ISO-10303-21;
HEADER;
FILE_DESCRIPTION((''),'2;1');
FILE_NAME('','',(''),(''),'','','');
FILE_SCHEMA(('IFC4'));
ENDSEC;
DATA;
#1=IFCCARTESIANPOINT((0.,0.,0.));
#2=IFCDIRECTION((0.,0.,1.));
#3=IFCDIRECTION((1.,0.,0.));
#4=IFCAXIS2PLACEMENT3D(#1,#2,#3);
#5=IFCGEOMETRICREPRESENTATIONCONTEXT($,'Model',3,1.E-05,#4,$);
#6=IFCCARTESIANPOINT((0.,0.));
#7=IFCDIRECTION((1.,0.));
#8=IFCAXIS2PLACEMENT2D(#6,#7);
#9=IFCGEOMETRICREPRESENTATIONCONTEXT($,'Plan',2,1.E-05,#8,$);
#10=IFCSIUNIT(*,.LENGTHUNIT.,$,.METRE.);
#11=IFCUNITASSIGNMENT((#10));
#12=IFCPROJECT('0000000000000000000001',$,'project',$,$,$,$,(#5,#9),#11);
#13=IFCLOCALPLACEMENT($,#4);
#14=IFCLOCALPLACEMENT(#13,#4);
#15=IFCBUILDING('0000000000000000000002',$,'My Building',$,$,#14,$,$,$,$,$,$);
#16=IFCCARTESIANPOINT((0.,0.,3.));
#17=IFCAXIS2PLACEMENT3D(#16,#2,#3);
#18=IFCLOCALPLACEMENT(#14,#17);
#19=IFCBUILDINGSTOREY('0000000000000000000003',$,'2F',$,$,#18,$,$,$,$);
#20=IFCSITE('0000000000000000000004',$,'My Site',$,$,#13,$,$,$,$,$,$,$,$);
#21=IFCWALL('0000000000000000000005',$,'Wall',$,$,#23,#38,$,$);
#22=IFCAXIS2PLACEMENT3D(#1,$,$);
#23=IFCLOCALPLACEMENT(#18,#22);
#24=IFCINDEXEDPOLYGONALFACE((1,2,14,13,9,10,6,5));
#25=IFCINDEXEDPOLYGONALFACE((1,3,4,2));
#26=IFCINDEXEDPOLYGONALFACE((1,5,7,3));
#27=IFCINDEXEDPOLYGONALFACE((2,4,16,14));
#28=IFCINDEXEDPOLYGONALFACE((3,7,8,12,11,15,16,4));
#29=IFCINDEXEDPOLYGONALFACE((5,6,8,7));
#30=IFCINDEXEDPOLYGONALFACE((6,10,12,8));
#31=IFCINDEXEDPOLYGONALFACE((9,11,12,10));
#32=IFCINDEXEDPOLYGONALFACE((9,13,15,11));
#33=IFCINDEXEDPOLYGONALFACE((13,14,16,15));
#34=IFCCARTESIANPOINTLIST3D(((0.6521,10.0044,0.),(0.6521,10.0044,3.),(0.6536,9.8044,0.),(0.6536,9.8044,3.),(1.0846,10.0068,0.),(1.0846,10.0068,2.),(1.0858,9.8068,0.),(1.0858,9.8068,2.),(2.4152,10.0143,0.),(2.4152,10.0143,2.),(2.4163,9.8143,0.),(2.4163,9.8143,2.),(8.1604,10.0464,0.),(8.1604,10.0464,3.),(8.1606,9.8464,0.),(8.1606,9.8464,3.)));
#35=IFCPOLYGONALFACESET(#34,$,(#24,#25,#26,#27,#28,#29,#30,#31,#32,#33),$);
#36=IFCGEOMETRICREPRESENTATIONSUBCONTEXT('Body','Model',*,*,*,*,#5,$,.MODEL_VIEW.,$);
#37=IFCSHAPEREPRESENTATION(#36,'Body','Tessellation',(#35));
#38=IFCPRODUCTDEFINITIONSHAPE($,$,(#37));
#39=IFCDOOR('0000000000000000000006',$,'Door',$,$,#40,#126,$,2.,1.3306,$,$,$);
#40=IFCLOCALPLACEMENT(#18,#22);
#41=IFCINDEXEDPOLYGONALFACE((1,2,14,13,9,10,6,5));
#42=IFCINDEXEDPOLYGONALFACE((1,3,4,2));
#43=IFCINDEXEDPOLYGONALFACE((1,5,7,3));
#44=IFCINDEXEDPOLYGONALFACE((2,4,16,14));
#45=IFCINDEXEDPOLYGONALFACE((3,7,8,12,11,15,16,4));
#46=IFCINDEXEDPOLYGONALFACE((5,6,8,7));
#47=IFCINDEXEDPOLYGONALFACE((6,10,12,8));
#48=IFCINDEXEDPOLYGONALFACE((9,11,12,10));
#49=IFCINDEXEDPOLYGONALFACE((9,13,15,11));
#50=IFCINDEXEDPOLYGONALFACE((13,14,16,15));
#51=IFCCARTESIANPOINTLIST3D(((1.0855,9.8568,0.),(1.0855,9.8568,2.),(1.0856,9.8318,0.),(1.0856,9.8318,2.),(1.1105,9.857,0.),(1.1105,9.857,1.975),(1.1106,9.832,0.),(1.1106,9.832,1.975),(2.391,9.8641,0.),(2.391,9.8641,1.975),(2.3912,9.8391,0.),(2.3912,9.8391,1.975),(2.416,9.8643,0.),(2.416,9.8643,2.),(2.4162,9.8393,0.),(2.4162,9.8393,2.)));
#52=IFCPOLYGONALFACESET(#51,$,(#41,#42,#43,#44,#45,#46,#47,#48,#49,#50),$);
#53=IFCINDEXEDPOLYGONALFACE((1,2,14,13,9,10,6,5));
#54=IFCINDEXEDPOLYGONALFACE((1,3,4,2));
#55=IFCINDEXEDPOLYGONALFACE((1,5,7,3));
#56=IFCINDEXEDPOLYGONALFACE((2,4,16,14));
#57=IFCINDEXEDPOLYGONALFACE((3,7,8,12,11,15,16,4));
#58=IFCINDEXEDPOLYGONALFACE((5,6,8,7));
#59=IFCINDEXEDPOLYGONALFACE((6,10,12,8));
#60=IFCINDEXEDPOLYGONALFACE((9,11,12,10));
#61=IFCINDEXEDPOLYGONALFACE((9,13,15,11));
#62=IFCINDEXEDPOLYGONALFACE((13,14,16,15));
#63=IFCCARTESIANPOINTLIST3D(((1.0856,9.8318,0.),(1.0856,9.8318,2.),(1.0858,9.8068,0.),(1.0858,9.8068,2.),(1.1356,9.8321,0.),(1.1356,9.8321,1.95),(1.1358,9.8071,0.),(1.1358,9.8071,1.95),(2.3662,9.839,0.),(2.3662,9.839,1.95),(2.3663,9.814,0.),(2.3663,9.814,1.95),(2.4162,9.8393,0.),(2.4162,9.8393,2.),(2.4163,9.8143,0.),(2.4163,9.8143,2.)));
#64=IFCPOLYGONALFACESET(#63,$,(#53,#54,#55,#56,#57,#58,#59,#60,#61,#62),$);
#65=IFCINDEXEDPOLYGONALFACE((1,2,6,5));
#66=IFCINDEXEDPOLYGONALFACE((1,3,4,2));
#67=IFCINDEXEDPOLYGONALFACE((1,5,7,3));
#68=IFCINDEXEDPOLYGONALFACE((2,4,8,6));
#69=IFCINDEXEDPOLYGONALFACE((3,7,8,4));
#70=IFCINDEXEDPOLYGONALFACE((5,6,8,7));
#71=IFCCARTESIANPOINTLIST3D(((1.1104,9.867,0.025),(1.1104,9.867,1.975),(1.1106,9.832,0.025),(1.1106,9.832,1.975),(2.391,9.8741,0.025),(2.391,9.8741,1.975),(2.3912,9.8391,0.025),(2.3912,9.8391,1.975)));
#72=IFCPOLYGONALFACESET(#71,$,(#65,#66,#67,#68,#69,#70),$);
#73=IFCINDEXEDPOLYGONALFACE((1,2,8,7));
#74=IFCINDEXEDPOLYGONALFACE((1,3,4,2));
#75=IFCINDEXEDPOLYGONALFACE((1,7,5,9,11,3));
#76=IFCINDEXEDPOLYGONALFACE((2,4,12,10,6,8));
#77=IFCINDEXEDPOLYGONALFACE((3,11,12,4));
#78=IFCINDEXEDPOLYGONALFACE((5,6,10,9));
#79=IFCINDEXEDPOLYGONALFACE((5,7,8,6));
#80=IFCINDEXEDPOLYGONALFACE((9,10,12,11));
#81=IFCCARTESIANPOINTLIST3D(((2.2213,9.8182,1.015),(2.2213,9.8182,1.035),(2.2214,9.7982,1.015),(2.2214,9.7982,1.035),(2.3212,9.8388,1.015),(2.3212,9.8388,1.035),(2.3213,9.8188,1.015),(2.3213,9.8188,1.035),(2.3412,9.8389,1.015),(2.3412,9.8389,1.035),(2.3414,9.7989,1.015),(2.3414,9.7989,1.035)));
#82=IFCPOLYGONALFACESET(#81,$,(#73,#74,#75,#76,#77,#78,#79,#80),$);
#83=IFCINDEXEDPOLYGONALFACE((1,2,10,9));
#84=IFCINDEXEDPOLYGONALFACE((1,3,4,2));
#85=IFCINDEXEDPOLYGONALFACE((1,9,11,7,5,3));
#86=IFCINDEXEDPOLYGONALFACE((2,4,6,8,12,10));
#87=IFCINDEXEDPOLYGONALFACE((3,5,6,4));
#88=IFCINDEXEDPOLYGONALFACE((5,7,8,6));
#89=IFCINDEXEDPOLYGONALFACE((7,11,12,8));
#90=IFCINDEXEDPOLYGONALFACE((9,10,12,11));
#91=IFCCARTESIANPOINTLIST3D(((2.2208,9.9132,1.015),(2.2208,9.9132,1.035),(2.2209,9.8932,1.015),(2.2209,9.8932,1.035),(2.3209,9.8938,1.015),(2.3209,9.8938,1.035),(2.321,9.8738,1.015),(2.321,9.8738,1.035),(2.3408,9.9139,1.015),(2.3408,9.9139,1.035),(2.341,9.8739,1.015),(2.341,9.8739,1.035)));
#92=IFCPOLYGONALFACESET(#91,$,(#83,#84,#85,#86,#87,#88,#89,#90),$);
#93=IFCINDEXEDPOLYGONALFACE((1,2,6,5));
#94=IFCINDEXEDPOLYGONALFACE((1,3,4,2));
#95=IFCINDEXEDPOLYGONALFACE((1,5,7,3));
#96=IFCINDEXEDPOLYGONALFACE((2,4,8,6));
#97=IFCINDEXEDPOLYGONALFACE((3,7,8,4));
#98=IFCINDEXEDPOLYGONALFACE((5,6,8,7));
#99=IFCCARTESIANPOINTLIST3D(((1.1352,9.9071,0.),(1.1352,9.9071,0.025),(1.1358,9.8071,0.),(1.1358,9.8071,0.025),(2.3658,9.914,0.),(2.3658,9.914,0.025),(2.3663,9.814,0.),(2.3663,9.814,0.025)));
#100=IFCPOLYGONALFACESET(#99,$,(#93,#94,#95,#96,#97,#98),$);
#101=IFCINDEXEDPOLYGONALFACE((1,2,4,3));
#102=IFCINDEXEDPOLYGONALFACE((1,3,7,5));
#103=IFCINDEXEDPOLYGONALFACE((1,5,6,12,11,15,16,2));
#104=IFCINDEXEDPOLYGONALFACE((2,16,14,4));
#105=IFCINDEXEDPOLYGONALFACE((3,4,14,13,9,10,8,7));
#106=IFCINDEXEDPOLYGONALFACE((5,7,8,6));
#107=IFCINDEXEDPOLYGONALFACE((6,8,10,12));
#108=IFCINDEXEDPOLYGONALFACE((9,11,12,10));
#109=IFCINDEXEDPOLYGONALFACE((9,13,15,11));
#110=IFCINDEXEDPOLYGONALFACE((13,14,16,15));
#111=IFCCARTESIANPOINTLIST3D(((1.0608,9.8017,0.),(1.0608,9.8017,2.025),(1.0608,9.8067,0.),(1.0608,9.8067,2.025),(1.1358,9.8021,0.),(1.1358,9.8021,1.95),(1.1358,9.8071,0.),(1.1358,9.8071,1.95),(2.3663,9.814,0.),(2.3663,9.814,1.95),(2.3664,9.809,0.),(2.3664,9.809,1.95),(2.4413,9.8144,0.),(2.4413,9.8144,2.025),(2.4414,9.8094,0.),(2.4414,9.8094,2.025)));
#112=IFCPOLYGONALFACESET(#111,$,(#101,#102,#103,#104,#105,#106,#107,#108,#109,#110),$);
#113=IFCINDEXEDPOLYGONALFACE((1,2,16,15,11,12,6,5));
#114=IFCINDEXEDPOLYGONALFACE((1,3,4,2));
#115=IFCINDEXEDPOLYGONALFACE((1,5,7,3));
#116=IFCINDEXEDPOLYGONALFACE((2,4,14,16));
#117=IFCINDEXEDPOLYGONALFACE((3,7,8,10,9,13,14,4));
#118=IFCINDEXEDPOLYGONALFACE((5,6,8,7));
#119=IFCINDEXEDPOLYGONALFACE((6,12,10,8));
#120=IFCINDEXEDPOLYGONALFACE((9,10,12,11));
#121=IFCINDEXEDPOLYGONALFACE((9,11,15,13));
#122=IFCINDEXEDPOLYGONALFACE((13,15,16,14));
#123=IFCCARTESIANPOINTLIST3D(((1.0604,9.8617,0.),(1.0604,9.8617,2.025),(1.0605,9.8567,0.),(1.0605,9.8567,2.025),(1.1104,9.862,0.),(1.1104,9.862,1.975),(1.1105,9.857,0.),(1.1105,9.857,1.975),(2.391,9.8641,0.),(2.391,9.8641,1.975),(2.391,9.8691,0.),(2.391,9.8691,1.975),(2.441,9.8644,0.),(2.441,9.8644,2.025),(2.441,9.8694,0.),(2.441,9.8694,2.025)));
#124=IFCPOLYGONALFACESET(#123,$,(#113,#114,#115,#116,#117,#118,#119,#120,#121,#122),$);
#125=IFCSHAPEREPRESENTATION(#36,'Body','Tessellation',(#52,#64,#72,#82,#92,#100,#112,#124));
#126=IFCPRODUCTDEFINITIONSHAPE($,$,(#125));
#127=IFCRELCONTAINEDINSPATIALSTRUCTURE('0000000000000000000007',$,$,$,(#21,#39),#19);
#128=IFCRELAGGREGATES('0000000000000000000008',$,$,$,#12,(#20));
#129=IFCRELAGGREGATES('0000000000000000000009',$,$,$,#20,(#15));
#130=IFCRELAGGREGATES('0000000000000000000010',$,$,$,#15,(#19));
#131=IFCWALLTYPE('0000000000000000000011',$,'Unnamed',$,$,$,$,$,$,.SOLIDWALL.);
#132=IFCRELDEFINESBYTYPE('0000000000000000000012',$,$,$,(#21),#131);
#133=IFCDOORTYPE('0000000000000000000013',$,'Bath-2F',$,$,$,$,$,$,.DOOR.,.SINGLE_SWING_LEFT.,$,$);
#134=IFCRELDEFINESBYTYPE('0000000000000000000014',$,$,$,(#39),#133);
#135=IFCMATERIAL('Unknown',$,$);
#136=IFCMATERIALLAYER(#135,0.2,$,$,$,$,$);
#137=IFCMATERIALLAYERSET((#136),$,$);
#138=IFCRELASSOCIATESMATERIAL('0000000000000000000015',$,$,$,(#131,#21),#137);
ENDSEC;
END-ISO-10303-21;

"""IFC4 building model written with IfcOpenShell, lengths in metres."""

from ifc_helpers import new_model, entity, si_unit, frame, origin_with_axes, origin_2d_with_axis, place, context, subcontext, project, spatial, line, indexed_curve, outline, extrude, shape, source, transform, mapped, material, layer, layer_set, layer_usage, type_object, type_shapes, element, fill, save


model = new_model("IFC4")

# Units and contexts
model_context = context("Model", 3, precision=1e-05, world=origin_with_axes())
plan_context = context("Plan", 2, precision=1e-05, world=origin_2d_with_axis())
body_context_1 = subcontext(model_context, "Body", "Model", "MODEL_VIEW")
body_context_2 = subcontext(plan_context, "Body", "Plan", "PLAN_VIEW")
ifc_project = project(units=[si_unit("LENGTHUNIT", "METRE")], contexts=[model_context, plan_context])

# Site, building, storey
site_placement = place(None, origin_with_axes())
site = spatial("IfcSite", under=ifc_project, at=site_placement, Name="My Site")
building_placement = place(site_placement, origin_with_axes())
building = spatial("IfcBuilding", under=site, at=building_placement, Name="My Building")
storey_placement = place(building_placement, frame((0.0, 0.0, 3.0), z_axis=(0.0, 0.0, 1.0), x_axis=(1.0, 0.0, 0.0)))
storey = spatial("IfcBuildingStorey", under=building, at=storey_placement, Name="2F")

# Shared definitions
ifc_material = material(Name="Unknown")

# Shared definitions
ifc_layer_1 = layer(ifc_material, 0.2)
ifc_layer_set_1 = layer_set([ifc_layer_1])
wall_type = type_object("IfcWallType", Name="Unnamed", PredefinedType="SOLIDWALL", material=ifc_layer_set_1)

# Wall, opening, door
ifc_layer_usage_1 = layer_usage(ifc_layer_set_1, "AXIS2", "POSITIVE", 0.0)
wall_1_placement = place(storey_placement, frame((0.4536, 9.8033, 0.0), z_axis=(0.0, 0.0, 1.0), x_axis=(0.999984, 0.00559, 0.0)))
wall_1 = element("IfcWall", 1, at=wall_1_placement, inside=storey, type_object=wall_type, material=ifc_layer_usage_1, Name="Wall", context=body_context_1, shape_type="SweptSolid", body=[
    extrude(outline(indexed_curve([(0.2, 0.0), (0.1997, 0.2), (7.708, 0.2), (7.7071, 0.0)], segments=[line(1, 2, 3, 4, 1)])), origin_with_axes(), (0.0, 0.0, 1.0), 3.0),
])
shared_shape_1 = source(origin_with_axes(), body_context_1, "Body", "SweptSolid", [
    extrude(outline(indexed_curve([(0.0, 0.0), (1.3306, 0.0), (1.3306, 2.0), (0.0, 2.0)], segments=[line(1, 2, 3, 4, 1)])), frame((0.0, -0.6, 0.0), z_axis=(0.0, -1.0, 0.0), x_axis=(1.0, 0.0, 0.0)), (0.0, 0.0, -1.0), 1.2),
])
opening_1_placement = place(wall_1_placement, frame((0.6322, 0.0, 0.0), z_axis=(0.0, 0.0, 1.0), x_axis=(1.0, 0.0, 0.0)))
opening_1 = element("IfcOpeningElement", 2, at=opening_1_placement, cuts=wall_1, PredefinedType="OPENING", context=body_context_1, shape_type="MappedRepresentation", body=[
    mapped(shared_shape_1, transform((0.0, 0.0, 0.0), x_axis=(1.0, 0.0, 0.0), y_axis=(0.0, 1.0, 0.0), z_axis=(0.0, 0.0, 1.0), scale=1.0)),
])
door_type_1 = type_object("IfcDoorType", Name="Bath-2F", OperationType="SINGLE_SWING_LEFT", PredefinedType="DOOR")
shared_shape_2 = source(origin_with_axes(), body_context_1, "Body", "SweptSolid", [
    extrude(outline(indexed_curve([(0.0, 0.0), (0.0, 2.0), (1.3306, 2.0), (1.3306, 0.0), (1.3056, 0.0), (1.3056, 1.975), (0.025, 1.975), (0.025, 0.0)], segments=[line(1, 2, 3, 4, 5, 6, 7, 8, 1)])), frame((0.0, 0.025, 0.0), z_axis=(0.0, -1.0, 0.0), x_axis=(1.0, 0.0, 0.0)), (0.0, 0.0, -1.0), 0.025),
    extrude(outline(indexed_curve([(0.0, 0.0), (0.0, 2.0), (1.3306, 2.0), (1.3306, 0.0), (1.2806, 0.0), (1.2806, 1.95), (0.05, 1.95), (0.05, 0.0)], segments=[line(1, 2, 3, 4, 5, 6, 7, 8, 1)])), frame((0.0, 0.0, 0.0), z_axis=(0.0, -1.0, 0.0), x_axis=(1.0, 0.0, 0.0)), (0.0, 0.0, -1.0), 0.025),
    extrude(outline(indexed_curve([(0.0, 0.0), (1.2806, 0.0), (1.2806, 0.035), (0.0, 0.035)], segments=[line(1, 2, 3, 4, 1)])), frame((0.025, 0.025, 0.025), z_axis=(0.0, 0.0, 1.0), x_axis=(1.0, 0.0, 0.0)), (0.0, 0.0, 1.0), 1.95),
    extrude(outline(indexed_curve([(0.0, 0.0), (0.0, -0.04), (-0.12, -0.04), (-0.12, -0.02), (-0.02, -0.02), (-0.02, 0.0)], segments=[line(1, 2, 3, 4, 5, 6, 1)])), frame((1.2556, 0.025, 1.015), z_axis=(0.0, 0.0, 1.0), x_axis=(1.0, 0.0, 0.0)), (0.0, 0.0, 1.0), 0.02),
    extrude(outline(indexed_curve([(0.0, 0.0), (0.0, 0.04), (-0.12, 0.04), (-0.12, 0.02), (-0.02, 0.02), (-0.02, 0.0)], segments=[line(1, 2, 3, 4, 5, 6, 1)])), frame((1.2556, 0.06, 1.015), z_axis=(0.0, 0.0, 1.0), x_axis=(1.0, 0.0, 0.0)), (0.0, 0.0, 1.0), 0.02),
    extrude(outline(indexed_curve([(0.0, 0.0), (1.2306, 0.0), (1.2306, 0.1), (0.0, 0.1)], segments=[line(1, 2, 3, 4, 1)])), frame((0.05, 0.0, 0.0), z_axis=(0.0, 0.0, 1.0), x_axis=(1.0, 0.0, 0.0)), (0.0, 0.0, 1.0), 0.025),
    extrude(outline(indexed_curve([(0.0, 0.0), (0.0, 2.025), (1.3806, 2.025), (1.3806, 0.0), (1.3056, 0.0), (1.3056, 1.95), (0.075, 1.95), (0.075, 0.0)], segments=[line(1, 2, 3, 4, 5, 6, 7, 8, 1)])), frame((-0.025, -0.005, 0.0), z_axis=(0.0, -1.0, 0.0), x_axis=(1.0, 0.0, 0.0)), (0.0, 0.0, -1.0), 0.005),
    extrude(outline(indexed_curve([(0.0, 0.0), (0.0, 2.025), (1.3806, 2.025), (1.3806, 0.0), (1.3306, 0.0), (1.3306, 1.975), (0.05, 1.975), (0.05, 0.0)], segments=[line(1, 2, 3, 4, 5, 6, 7, 8, 1)])), frame((-0.025, 0.05, 0.0), z_axis=(0.0, -1.0, 0.0), x_axis=(1.0, 0.0, 0.0)), (0.0, 0.0, -1.0), 0.005),
])
shared_shape_3 = source(origin_with_axes(), body_context_2, "Body", "Curve2D", [
    entity("IfcIndexedPolyCurve", entity("IfcCartesianPointList2D", [[0.0, 0.0], [0.0, 0.05], [0.025, 0.05], [0.025, 0.025], [0.05, 0.025], [0.05, 0.0]]), [entity("IfcLineIndex", [1, 2, 3, 4, 5, 6, 1])]),
    entity("IfcIndexedPolyCurve", entity("IfcCartesianPointList2D", [[1.3306, 0.0], [1.3306, 0.05], [1.3056, 0.05], [1.3056, 0.025], [1.2806, 0.025], [1.2806, 0.0]]), [entity("IfcLineIndex", [1, 2, 3, 4, 5, 6, 1])]),
    entity("IfcTrimmedCurve", entity("IfcEllipse", entity("IfcAxis2Placement2D", entity("IfcCartesianPoint", [0.06, 0.05]), entity("IfcDirection", [1.0, 0.0])), 1.2456, 1.2806), [entity("IfcCartesianPoint", [1.3056, 0.05])], [entity("IfcCartesianPoint", [0.06, 1.3306])], True, "CARTESIAN"),
    entity("IfcIndexedPolyCurve", entity("IfcCartesianPointList2D", [[0.025, 0.05], [0.06, 0.05], [0.06, 1.3306], [0.025, 1.3306]]), [entity("IfcLineIndex", [1, 2, 3, 4, 1])]),
])
type_shapes(door_type_1, [shared_shape_2, shared_shape_3])
door_1_placement = place(opening_1_placement, frame((0.0, 0.0, 0.0), z_axis=(0.0, 0.0, 1.0), x_axis=(1.0, 0.0, 0.0)))
door_1 = element("IfcDoor", 3, at=door_1_placement, inside=storey, type_object=door_type_1, Name="Door", OverallHeight=2.0, OverallWidth=1.3306, shapes=[
    shape(body_context_1, "Body", "MappedRepresentation", [mapped(shared_shape_2, transform((0.0, 0.0, 0.0), x_axis=(1.0, 0.0, 0.0), y_axis=(0.0, 1.0, 0.0), z_axis=(0.0, 0.0, 1.0), scale=1.0))]),
    shape(body_context_2, "Body", "MappedRepresentation", [mapped(shared_shape_3, transform((0.0, 0.0, 0.0), x_axis=(1.0, 0.0, 0.0), y_axis=(0.0, 1.0, 0.0), z_axis=(0.0, 0.0, 1.0), scale=1.0))]),
])
fill(opening_1, door_1)

save(model, "model.ifc")
